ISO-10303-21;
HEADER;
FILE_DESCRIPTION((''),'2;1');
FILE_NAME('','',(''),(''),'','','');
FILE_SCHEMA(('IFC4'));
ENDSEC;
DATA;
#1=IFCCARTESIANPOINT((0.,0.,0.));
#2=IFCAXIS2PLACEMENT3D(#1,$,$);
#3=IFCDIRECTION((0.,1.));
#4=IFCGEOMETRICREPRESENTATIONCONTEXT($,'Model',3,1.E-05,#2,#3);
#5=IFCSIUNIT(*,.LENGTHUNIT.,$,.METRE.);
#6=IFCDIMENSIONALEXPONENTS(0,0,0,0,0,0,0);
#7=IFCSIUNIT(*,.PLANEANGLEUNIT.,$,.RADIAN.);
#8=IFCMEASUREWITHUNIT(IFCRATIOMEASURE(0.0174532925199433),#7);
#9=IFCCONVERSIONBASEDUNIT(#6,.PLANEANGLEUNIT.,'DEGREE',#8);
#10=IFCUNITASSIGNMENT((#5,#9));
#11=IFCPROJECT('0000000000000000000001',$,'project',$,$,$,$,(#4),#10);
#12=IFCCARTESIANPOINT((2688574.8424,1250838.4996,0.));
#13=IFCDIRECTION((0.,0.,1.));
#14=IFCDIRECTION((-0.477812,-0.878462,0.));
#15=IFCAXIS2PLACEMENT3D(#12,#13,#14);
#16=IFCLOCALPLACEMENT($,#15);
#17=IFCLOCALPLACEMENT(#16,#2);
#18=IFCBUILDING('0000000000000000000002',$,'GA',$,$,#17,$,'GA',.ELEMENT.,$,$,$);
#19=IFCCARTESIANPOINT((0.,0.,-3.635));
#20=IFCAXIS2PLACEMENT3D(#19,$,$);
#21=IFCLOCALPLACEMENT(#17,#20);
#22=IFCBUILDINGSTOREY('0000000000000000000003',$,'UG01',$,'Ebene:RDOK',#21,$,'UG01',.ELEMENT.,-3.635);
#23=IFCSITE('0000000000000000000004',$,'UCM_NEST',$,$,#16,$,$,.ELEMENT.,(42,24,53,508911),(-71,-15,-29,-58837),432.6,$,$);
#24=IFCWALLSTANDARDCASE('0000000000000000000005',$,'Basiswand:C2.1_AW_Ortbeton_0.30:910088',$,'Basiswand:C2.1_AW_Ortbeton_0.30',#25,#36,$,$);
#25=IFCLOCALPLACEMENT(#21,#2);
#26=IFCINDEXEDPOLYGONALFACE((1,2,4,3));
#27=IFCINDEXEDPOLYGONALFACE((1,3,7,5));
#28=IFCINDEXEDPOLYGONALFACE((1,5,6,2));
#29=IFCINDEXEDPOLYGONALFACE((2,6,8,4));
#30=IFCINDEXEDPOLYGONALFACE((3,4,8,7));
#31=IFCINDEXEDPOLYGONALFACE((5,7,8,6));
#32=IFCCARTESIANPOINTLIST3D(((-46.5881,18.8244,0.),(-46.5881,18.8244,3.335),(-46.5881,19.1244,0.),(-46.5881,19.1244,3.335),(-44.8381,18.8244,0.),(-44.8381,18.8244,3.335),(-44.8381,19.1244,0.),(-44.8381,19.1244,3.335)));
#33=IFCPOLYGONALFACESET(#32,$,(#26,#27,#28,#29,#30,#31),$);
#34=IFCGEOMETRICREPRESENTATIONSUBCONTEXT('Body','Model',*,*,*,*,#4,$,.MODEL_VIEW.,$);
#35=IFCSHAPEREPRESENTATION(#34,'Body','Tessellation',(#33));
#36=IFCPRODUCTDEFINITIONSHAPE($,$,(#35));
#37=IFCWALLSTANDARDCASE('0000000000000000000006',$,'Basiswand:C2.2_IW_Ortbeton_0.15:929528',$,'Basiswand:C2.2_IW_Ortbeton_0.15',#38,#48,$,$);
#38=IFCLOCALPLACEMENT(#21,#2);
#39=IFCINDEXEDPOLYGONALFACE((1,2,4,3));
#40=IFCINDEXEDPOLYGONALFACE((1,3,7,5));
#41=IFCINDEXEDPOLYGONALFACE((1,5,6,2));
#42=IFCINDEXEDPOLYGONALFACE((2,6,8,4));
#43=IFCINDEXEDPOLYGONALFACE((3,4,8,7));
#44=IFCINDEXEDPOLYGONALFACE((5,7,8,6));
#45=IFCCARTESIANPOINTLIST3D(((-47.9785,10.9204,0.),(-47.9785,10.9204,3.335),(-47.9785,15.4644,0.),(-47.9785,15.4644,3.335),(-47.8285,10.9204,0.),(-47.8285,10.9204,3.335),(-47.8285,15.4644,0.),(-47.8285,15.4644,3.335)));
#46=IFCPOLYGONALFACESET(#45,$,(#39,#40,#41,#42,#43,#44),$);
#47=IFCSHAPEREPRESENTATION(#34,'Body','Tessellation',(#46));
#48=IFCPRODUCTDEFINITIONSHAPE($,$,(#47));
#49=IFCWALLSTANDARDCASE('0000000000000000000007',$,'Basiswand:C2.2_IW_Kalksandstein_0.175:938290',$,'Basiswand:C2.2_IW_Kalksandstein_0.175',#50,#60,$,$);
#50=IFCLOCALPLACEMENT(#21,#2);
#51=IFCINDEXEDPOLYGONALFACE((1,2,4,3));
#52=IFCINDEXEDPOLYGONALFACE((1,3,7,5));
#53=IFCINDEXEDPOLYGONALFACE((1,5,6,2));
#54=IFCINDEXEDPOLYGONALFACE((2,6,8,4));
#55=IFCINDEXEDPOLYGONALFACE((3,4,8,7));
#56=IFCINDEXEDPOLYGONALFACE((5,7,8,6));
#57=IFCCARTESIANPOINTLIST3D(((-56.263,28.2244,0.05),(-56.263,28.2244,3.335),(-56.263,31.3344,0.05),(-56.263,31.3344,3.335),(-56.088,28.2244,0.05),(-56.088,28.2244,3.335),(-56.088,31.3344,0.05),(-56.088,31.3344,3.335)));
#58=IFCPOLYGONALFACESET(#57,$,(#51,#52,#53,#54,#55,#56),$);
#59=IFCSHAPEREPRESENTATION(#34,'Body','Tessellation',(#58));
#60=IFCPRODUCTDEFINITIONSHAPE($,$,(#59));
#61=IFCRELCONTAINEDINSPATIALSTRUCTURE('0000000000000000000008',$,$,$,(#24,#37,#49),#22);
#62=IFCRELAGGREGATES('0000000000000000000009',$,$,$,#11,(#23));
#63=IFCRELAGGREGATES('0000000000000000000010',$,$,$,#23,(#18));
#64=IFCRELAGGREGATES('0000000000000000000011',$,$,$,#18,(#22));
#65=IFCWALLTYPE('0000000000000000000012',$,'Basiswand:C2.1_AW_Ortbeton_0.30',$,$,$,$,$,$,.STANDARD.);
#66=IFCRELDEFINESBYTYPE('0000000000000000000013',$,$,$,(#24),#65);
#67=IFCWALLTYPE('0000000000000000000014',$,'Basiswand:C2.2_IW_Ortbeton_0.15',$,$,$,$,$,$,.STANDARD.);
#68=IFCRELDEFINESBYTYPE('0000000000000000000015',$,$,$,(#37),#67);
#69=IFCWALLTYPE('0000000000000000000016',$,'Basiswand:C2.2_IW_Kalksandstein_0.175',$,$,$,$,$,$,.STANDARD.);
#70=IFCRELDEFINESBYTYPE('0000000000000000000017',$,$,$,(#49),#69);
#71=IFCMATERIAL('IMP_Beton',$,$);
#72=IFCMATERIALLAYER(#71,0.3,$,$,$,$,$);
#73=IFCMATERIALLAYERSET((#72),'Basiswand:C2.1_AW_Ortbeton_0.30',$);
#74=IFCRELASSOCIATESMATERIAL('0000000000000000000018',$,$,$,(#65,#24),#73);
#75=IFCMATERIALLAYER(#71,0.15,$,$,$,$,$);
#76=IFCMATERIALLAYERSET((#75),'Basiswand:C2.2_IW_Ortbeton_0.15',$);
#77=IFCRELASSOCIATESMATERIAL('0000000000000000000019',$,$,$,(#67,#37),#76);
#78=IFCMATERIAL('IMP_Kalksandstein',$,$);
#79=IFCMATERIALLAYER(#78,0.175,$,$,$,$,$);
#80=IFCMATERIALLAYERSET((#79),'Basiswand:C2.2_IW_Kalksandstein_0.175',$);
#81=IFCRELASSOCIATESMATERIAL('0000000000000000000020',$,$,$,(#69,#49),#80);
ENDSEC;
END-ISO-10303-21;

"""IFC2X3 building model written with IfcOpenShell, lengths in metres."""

from ifc_helpers import new_model, entity, si_unit, converted_unit, direction, frame, frame_2d, origin, place, context, subcontext, project, spatial, polyline, rectangle, extrude, clip, bounded_halfspace, material, layer, layer_set, layer_usage, type_object, element, save


model = new_model("IFC2X3")

# Units and contexts
model_context = context("Model", 3, precision=1e-05, world=origin(), true_north=direction((0.0, 1.0)))
body_context = subcontext(model_context, "Body", "Model", "MODEL_VIEW")
ifc_project = project(units=[si_unit("LENGTHUNIT", "METRE"), converted_unit("PLANEANGLEUNIT", "DEGREE", entity("IfcRatioMeasure", 0.0174532925199433), si_unit("PLANEANGLEUNIT", "RADIAN"), dimensions=[0, 0, 0, 0, 0, 0, 0])], contexts=[model_context])

# Site, building, storey
site_placement = place(None, frame((2688574.8424, 1250838.4996, 0.0), z_axis=(0.0, 0.0, 1.0), x_axis=(-0.477812, -0.878462, 0.0)))
site = spatial("IfcSite", under=ifc_project, at=site_placement, Name="UCM_NEST", CompositionType="ELEMENT", RefLatitude=(42, 24, 53, 508911), RefLongitude=(-71, -15, -29, -58837), RefElevation=432.6)
building_placement = place(site_placement, origin())
building = spatial("IfcBuilding", under=site, at=building_placement, Name="GA", LongName="GA", CompositionType="ELEMENT")
storey_placement = place(building_placement, frame((0.0, 0.0, -3.635)))
storey = spatial("IfcBuildingStorey", under=building, at=storey_placement, Name="UG01", ObjectType="Ebene:RDOK", LongName="UG01", CompositionType="ELEMENT", Elevation=-3.635)

# Shared definitions
ifc_material_1 = material(Name="IMP_Beton")

# Walls
ifc_layer_1 = layer(ifc_material_1, 0.3)
ifc_layer_set_1 = layer_set([ifc_layer_1], Name="Basiswand:C2.1_AW_Ortbeton_0.30")
ifc_layer_usage_1 = layer_usage(ifc_layer_set_1, "AXIS2", "NEGATIVE", 0.15)
wall_type_1 = type_object("IfcWallType", Name="Basiswand:C2.1_AW_Ortbeton_0.30", PredefinedType="STANDARD", material=ifc_layer_set_1)
wall_1_placement = place(storey_placement, frame((-46.5881, 18.9744, 0.0)))
element("IfcWallStandardCase", 1, at=wall_1_placement, inside=storey, type_object=wall_type_1, material=ifc_layer_usage_1, Name="Basiswand:C2.1_AW_Ortbeton_0.30:910088", ObjectType="Basiswand:C2.1_AW_Ortbeton_0.30", context=body_context, shape_type="SweptSolid", body=[
    extrude(rectangle(XDim=1.75, YDim=0.3, at=frame_2d((0.875, 0.0), x_axis=(-1.0, 0.0))), origin(), (0.0, 0.0, 1.0), 3.335),
])
ifc_layer_2 = layer(ifc_material_1, 0.15)
ifc_layer_set_2 = layer_set([ifc_layer_2], Name="Basiswand:C2.2_IW_Ortbeton_0.15")
ifc_layer_usage_2 = layer_usage(ifc_layer_set_2, "AXIS2", "NEGATIVE", 0.075)
wall_type_2 = type_object("IfcWallType", Name="Basiswand:C2.2_IW_Ortbeton_0.15", PredefinedType="STANDARD", material=ifc_layer_set_2)
wall_2_placement = place(storey_placement, frame((-47.9035, 15.4644, 0.0), z_axis=(0.0, 0.0, 1.0), x_axis=(0.0, -1.0, 0.0)))
element("IfcWallStandardCase", 2, at=wall_2_placement, inside=storey, type_object=wall_type_2, material=ifc_layer_usage_2, Name="Basiswand:C2.2_IW_Ortbeton_0.15:929528", ObjectType="Basiswand:C2.2_IW_Ortbeton_0.15", context=body_context, shape_type="SweptSolid", body=[
    extrude(rectangle(XDim=4.544, YDim=0.15, at=frame_2d((2.272, 0.0), x_axis=(-1.0, 0.0))), origin(), (0.0, 0.0, 1.0), 3.335),
])
ifc_material_2 = material(Name="IMP_Kalksandstein")
ifc_layer_3 = layer(ifc_material_2, 0.175)
ifc_layer_set_3 = layer_set([ifc_layer_3], Name="Basiswand:C2.2_IW_Kalksandstein_0.175")
ifc_layer_usage_3 = layer_usage(ifc_layer_set_3, "AXIS2", "NEGATIVE", 0.0875)
wall_type_3 = type_object("IfcWallType", Name="Basiswand:C2.2_IW_Kalksandstein_0.175", PredefinedType="STANDARD", material=ifc_layer_set_3)
wall_3_placement = place(storey_placement, frame((-56.1755, 28.2244, 0.05), z_axis=(0.0, 0.0, 1.0), x_axis=(0.0, 1.0, 0.0)))
element("IfcWallStandardCase", 3, at=wall_3_placement, inside=storey, type_object=wall_type_3, material=ifc_layer_usage_3, Name="Basiswand:C2.2_IW_Kalksandstein_0.175:938290", ObjectType="Basiswand:C2.2_IW_Kalksandstein_0.175", context=body_context, shape_type="Clipping", body=[
    clip(extrude(rectangle(XDim=3.11, YDim=0.175, at=frame_2d((1.555, 0.0), x_axis=(-1.0, 0.0))), origin(), (0.0, 0.0, 1.0), 3.285), bounded_halfspace(frame((3.11, -0.0875, 0.0)), True, frame((3.11, -0.0875, 0.0)), polyline([(0.0, 0.0), (0.0, 0.175), (-3.11, 0.175), (-3.11, 0.0), (0.0, 0.0)]))),
])

save(model, "model.ifc")
